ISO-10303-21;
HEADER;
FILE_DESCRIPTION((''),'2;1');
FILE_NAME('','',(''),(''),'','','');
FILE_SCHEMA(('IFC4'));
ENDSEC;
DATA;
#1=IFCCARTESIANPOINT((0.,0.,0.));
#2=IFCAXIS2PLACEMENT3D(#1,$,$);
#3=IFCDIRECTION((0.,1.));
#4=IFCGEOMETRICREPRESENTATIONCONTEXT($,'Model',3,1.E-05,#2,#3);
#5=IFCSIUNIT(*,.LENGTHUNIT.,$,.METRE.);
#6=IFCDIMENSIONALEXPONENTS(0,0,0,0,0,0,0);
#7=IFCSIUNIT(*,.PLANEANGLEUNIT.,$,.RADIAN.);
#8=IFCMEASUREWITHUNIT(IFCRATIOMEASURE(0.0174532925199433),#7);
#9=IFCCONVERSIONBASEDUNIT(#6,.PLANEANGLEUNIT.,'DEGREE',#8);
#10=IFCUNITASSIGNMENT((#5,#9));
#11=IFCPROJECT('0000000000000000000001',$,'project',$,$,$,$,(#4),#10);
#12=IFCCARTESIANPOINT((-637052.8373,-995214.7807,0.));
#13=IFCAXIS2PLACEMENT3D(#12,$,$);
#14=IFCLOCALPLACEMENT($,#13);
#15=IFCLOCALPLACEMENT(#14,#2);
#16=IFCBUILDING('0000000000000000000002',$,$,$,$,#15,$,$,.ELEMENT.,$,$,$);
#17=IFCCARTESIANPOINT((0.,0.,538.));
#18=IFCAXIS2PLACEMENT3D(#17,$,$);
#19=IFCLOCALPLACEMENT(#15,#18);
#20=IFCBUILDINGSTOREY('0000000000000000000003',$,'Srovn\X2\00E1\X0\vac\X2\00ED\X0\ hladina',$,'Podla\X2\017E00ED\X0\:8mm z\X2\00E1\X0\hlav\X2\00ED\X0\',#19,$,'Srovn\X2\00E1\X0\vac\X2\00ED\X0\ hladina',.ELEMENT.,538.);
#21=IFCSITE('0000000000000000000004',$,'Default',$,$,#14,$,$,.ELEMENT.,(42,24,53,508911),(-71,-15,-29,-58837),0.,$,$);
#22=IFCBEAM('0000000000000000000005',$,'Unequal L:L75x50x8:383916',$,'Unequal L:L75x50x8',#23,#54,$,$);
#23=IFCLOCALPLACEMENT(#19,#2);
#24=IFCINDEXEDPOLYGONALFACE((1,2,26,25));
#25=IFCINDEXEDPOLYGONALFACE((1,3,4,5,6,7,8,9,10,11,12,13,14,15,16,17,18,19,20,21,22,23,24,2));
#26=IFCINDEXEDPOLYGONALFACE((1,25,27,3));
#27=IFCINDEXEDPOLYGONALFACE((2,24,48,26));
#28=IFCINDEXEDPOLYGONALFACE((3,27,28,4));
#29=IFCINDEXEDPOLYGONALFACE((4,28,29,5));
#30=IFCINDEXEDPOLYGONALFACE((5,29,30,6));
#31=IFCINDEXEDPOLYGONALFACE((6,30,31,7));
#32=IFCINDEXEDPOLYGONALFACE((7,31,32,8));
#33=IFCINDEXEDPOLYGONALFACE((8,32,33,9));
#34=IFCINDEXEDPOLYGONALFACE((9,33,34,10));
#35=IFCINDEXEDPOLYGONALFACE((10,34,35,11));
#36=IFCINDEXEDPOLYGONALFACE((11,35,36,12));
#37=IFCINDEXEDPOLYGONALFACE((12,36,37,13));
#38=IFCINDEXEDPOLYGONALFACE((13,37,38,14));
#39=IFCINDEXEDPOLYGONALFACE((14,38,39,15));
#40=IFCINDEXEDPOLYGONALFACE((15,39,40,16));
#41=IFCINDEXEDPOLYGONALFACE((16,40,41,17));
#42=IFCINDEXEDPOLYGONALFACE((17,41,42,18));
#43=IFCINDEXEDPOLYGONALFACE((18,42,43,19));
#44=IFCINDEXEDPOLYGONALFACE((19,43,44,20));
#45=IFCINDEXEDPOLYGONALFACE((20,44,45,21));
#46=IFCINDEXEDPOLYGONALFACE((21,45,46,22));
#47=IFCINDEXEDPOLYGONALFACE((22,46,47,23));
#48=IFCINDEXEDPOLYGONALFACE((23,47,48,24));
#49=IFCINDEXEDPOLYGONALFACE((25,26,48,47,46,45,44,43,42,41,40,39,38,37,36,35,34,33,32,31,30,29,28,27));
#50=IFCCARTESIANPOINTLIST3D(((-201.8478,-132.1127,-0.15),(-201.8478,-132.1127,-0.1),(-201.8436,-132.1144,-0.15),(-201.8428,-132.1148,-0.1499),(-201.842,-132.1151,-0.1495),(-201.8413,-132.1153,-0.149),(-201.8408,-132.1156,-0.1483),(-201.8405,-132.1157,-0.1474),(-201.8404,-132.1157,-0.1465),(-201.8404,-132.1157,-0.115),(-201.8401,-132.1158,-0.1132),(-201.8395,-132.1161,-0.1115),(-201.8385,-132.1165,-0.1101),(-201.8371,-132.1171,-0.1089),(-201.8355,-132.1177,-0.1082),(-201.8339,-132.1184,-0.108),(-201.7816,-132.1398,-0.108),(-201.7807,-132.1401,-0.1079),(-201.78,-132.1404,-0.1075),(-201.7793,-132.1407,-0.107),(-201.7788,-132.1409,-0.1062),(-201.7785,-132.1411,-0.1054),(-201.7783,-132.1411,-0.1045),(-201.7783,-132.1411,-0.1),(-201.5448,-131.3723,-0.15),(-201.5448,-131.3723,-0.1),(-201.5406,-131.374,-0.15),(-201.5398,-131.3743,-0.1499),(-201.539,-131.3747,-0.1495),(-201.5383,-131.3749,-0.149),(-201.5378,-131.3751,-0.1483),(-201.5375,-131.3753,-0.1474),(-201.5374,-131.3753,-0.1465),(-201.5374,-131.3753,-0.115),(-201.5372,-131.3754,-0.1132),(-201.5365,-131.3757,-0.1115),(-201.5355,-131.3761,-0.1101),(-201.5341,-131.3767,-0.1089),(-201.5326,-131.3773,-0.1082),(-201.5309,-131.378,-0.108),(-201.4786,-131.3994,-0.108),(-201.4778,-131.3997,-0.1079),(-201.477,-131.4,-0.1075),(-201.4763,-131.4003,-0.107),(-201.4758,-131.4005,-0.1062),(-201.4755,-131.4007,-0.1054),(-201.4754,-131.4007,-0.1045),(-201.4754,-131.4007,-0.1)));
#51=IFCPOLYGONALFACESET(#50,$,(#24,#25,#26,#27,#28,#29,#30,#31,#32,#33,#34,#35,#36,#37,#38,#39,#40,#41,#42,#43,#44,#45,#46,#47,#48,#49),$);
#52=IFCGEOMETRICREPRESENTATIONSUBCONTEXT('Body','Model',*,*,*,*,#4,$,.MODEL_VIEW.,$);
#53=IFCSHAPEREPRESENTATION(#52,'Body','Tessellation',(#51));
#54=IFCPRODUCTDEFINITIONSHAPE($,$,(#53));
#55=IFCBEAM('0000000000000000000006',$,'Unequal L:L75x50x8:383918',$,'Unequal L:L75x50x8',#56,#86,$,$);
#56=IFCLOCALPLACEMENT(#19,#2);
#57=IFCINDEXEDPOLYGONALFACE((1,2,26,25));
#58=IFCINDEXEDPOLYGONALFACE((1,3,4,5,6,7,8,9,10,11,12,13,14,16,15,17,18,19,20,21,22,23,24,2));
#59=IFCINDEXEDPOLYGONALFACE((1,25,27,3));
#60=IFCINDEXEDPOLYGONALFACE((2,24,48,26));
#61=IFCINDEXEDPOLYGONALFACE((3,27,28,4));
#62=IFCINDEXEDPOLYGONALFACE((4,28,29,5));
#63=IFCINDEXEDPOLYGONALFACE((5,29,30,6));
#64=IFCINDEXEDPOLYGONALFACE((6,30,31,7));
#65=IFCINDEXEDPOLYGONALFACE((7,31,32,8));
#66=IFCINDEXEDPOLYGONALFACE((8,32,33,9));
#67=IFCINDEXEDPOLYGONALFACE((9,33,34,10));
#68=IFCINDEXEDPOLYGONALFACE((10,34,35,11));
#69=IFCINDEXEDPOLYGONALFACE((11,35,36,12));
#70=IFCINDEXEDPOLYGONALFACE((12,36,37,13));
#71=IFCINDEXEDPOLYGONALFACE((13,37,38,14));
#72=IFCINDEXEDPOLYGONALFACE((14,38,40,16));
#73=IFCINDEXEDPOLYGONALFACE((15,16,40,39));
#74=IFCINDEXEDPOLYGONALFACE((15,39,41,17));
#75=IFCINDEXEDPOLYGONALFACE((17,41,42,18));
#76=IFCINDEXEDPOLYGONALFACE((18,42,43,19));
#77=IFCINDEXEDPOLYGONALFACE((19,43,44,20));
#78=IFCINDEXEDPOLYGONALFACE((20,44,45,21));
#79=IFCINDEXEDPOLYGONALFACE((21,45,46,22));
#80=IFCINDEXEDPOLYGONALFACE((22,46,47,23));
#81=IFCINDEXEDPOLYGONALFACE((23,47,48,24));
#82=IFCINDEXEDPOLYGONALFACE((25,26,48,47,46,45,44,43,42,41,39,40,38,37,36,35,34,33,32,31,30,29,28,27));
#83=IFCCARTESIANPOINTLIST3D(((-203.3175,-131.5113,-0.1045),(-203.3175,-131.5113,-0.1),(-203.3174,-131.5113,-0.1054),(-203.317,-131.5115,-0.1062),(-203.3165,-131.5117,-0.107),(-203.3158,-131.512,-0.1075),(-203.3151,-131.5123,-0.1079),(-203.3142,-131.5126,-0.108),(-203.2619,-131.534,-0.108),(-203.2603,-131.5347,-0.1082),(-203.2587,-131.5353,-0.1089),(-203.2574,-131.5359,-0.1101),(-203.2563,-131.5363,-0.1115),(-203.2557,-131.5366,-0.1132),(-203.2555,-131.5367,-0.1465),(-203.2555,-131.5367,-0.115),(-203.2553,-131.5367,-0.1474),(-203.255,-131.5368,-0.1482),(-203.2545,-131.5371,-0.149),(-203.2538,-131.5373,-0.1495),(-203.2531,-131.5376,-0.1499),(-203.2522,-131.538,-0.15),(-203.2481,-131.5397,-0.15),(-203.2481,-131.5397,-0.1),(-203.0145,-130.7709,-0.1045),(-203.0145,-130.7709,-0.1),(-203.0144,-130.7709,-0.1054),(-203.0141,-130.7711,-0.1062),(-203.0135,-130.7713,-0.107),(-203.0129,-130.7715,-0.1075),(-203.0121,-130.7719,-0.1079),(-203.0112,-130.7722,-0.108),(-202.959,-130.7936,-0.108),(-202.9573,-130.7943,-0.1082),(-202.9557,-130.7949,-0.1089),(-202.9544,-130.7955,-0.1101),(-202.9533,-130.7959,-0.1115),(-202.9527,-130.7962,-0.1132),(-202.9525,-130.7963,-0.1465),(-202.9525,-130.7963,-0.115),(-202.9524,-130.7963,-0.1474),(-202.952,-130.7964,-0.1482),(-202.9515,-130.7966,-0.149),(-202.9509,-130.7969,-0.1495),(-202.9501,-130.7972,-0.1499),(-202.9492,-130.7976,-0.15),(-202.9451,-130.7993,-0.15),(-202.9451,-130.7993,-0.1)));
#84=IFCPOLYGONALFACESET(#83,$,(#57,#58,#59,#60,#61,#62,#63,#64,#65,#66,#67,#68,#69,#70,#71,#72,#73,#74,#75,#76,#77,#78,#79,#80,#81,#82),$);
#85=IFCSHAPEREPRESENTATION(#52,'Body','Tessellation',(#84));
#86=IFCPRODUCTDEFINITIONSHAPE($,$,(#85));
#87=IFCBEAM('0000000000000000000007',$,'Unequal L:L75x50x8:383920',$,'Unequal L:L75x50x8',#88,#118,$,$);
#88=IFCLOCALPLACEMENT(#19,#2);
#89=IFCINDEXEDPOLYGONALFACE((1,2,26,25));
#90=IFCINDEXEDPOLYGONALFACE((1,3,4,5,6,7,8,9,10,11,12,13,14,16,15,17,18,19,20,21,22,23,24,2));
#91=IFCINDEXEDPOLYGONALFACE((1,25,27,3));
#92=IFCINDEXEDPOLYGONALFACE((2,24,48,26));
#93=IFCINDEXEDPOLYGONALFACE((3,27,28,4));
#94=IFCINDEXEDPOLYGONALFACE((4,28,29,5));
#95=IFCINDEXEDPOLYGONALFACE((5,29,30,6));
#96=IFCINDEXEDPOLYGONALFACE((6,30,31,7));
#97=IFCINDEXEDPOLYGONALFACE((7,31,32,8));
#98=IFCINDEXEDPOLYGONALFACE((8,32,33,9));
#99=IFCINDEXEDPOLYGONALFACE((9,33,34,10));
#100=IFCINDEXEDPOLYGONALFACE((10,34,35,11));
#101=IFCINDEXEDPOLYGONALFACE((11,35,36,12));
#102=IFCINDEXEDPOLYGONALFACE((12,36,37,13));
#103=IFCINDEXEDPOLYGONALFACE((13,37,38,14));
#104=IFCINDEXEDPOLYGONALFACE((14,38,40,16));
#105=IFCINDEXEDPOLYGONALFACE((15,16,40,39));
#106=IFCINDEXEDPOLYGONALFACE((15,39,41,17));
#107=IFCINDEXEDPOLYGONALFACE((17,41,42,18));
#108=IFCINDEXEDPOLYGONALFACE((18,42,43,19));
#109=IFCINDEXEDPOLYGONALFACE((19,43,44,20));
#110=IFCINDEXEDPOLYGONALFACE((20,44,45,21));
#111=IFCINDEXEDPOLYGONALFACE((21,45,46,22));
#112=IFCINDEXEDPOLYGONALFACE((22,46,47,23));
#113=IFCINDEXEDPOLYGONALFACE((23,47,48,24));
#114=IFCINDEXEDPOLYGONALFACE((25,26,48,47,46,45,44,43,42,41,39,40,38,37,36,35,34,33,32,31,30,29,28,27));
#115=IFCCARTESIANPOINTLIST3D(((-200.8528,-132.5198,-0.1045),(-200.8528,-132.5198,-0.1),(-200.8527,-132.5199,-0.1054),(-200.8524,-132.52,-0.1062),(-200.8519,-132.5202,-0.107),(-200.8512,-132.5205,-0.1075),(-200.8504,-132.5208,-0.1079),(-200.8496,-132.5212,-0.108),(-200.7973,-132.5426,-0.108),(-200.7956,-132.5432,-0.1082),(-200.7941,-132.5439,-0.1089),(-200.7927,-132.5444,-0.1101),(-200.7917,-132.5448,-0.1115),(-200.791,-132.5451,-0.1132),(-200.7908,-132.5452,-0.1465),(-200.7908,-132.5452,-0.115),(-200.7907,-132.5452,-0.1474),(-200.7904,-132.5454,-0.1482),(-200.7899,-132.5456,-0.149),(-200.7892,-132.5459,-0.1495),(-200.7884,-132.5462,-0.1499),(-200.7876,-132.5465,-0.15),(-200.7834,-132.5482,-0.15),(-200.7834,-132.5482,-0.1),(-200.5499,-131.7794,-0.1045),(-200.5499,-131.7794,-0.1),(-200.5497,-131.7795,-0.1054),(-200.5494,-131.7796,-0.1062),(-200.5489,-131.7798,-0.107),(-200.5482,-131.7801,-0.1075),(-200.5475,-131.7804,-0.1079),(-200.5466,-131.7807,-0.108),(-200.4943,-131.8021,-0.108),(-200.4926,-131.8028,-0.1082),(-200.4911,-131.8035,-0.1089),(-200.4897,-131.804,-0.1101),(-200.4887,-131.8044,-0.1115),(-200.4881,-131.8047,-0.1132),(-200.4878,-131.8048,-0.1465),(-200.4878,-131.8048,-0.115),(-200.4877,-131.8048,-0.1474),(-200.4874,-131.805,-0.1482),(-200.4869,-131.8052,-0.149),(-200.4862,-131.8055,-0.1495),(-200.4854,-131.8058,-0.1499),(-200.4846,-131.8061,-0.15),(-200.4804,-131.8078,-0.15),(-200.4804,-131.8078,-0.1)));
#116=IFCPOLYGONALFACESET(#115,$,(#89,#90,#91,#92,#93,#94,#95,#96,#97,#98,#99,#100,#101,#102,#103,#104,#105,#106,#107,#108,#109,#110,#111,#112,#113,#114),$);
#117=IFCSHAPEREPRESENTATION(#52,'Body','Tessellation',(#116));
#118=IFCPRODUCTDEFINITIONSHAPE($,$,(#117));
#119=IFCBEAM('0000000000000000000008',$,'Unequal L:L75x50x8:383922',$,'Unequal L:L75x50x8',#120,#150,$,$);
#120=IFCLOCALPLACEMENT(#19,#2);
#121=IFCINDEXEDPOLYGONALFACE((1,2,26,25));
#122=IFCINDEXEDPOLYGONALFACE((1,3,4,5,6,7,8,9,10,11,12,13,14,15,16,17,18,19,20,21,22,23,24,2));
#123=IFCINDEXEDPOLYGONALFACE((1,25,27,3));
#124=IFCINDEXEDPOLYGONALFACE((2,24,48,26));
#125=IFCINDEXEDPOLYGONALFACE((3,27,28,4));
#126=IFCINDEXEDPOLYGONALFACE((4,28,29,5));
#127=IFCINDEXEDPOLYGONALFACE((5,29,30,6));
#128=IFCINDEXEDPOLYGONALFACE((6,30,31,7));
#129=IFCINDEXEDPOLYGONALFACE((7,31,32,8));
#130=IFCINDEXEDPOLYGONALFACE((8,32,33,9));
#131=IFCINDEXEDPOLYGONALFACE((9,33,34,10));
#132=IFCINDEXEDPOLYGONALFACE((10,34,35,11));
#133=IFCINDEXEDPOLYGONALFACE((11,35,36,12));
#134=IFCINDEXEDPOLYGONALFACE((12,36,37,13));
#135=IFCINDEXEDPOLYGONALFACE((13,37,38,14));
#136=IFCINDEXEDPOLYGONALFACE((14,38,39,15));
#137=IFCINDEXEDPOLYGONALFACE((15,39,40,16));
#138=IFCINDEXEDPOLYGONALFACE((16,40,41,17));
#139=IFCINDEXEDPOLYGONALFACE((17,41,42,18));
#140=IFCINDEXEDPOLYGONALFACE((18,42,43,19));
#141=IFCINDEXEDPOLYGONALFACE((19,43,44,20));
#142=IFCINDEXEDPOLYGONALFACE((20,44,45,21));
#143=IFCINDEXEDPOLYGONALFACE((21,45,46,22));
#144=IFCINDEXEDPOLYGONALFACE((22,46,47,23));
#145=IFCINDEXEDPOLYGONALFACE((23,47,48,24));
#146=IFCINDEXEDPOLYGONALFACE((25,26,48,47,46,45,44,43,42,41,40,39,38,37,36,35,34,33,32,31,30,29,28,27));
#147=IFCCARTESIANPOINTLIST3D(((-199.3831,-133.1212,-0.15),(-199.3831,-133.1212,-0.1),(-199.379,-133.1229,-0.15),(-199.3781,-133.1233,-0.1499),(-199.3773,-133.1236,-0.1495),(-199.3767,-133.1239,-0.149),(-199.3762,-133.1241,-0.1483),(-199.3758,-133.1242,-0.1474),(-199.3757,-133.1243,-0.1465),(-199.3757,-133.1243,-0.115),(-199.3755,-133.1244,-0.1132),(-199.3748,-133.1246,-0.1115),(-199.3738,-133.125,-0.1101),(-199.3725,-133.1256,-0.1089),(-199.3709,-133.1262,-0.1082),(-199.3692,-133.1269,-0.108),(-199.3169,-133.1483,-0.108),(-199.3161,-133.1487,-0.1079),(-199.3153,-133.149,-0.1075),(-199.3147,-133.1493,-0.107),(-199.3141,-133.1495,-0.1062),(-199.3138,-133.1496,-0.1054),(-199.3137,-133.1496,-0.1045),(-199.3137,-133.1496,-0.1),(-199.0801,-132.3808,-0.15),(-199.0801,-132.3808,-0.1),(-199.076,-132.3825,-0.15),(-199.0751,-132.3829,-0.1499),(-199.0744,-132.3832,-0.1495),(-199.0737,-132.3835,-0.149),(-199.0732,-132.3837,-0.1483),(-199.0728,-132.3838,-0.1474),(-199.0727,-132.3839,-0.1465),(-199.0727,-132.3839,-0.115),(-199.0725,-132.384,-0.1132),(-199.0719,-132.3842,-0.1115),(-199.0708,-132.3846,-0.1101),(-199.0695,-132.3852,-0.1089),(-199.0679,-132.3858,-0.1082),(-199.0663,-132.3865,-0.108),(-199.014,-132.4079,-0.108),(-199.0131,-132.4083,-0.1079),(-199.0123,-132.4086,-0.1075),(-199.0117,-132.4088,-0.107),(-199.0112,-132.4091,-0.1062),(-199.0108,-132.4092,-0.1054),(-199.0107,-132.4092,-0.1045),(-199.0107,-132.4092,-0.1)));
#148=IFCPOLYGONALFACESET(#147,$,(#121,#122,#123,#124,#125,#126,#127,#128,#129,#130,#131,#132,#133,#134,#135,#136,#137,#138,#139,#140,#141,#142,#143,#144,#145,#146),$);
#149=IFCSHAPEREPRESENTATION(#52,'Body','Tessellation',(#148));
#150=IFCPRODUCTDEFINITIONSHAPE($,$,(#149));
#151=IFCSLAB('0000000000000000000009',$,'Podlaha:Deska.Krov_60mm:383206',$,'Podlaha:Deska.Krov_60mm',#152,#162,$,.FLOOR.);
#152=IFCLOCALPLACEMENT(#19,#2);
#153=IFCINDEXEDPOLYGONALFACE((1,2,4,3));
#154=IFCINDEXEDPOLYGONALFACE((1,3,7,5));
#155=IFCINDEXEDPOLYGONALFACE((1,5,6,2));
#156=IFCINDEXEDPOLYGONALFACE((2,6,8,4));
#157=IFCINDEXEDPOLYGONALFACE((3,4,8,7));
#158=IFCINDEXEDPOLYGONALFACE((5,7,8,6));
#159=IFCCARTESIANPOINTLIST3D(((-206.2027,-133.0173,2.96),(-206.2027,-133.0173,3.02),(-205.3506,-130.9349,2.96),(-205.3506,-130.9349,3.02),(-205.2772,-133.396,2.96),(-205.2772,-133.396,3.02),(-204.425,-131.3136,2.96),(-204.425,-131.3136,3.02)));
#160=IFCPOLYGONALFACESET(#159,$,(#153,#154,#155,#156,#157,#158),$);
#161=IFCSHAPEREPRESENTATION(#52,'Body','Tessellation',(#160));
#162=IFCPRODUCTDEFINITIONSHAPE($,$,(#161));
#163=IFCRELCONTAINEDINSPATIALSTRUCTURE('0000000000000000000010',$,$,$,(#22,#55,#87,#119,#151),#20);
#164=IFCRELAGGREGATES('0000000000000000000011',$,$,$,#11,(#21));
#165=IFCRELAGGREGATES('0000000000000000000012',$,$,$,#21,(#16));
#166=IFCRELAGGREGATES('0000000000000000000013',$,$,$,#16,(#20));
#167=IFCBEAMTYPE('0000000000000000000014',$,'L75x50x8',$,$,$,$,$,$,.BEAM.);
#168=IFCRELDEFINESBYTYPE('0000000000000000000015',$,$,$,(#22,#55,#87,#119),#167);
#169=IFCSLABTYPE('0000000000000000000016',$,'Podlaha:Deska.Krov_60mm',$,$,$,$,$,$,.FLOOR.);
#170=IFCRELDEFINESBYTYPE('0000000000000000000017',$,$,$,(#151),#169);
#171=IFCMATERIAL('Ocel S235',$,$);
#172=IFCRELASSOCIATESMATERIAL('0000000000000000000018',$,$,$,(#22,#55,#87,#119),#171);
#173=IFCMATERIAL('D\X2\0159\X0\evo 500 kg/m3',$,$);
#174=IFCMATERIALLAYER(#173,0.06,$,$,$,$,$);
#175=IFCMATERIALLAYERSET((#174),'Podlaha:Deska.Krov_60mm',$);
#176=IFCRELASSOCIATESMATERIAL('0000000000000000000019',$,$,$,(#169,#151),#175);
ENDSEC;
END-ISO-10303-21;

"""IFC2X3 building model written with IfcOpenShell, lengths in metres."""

from ifc_helpers import new_model, entity, si_unit, converted_unit, direction, frame, frame_2d, origin, origin_2d_with_axis, place, context, subcontext, project, spatial, polyline, circle_curve, parameter, trimmed, segment, composite_curve, rectangle, outline, extrude, material, layer, layer_set, layer_usage, type_object, element, save


model = new_model("IFC2X3")

# Units and contexts
model_context = context("Model", 3, precision=1e-05, world=origin(), true_north=direction((0.0, 1.0)))
body_context = subcontext(model_context, "Body", "Model", "MODEL_VIEW")
ifc_project = project(units=[si_unit("LENGTHUNIT", "METRE"), converted_unit("PLANEANGLEUNIT", "DEGREE", entity("IfcRatioMeasure", 0.0174532925199433), si_unit("PLANEANGLEUNIT", "RADIAN"), dimensions=[0, 0, 0, 0, 0, 0, 0])], contexts=[model_context])

# Site, building, storey
site_placement = place(None, frame((-637052.8373, -995214.7807, 0.0)))
site = spatial("IfcSite", under=ifc_project, at=site_placement, Name="Default", CompositionType="ELEMENT", RefLatitude=(42, 24, 53, 508911), RefLongitude=(-71, -15, -29, -58837), RefElevation=0.0)
building_placement = place(site_placement, origin())
building = spatial("IfcBuilding", under=site, at=building_placement, CompositionType="ELEMENT")
storey_placement = place(building_placement, frame((0.0, 0.0, 538.0)))
storey = spatial("IfcBuildingStorey", under=building, at=storey_placement, Name="Srovnávací hladina", ObjectType="Podlaží:8mm záhlaví", LongName="Srovnávací hladina", CompositionType="ELEMENT", Elevation=538.0)

# Beams
ifc_material_1 = material(Name="Ocel S235")
beam_type = type_object("IfcBeamType", Name="L75x50x8", PredefinedType="BEAM")
beam_1_placement = place(storey_placement, frame((-201.7693, -132.1189, 0.0), z_axis=(0.0, 0.0, 1.0), x_axis=(0.378722, 0.92551, 0.0)))
element("IfcBeam", 1, at=beam_1_placement, inside=storey, type_object=beam_type, material=ifc_material_1, Name="Unequal L:L75x50x8:383916", ObjectType="Unequal L:L75x50x8", context=body_context, shape_type="SweptSolid", body=[
    extrude(outline(composite_curve([segment(polyline([(-0.0202, -0.0464), (-0.0157, -0.0464)]), True, "CONTINUOUS"), segment(trimmed(circle_curve(frame_2d((-0.0157, -0.0429), x_axis=(0.0, -1.0)), 0.0035), [parameter(0.0)], [parameter(90.0)], True, "PARAMETER"), True, "CONTINUOUS"), segment(polyline([(-0.0122, -0.0429), (-0.0122, 0.0136)]), True, "CONTINUOUS"), segment(trimmed(circle_curve(frame_2d((-0.0052, 0.0136), x_axis=(-1.0, 0.0)), 0.007), [parameter(270.0)], [parameter(0.0)], True, "PARAMETER"), False, "CONTINUOUS"), segment(polyline([(-0.0052, 0.0206), (0.0263, 0.0206)]), True, "CONTINUOUS"), segment(trimmed(circle_curve(frame_2d((0.0263, 0.0241), x_axis=(0.0, -1.0)), 0.0035), [parameter(0.0)], [parameter(90.0)], True, "PARAMETER"), True, "CONTINUOUS"), segment(polyline([(0.0298, 0.0241), (0.0298, 0.0286)]), True, "CONTINUOUS"), segment(polyline([(0.0298, 0.0286), (-0.0202, 0.0286)]), True, "CONTINUOUS"), segment(polyline([(-0.0202, 0.0286), (-0.0202, -0.0464)]), True, "CONTINUOUS")], self_intersect=False)), frame((-0.024, 0.0464, -0.1202), z_axis=(1.0, 0.0, 0.0), x_axis=(0.0, 0.0, -1.0)), (0.0, 0.0, 1.0), 0.8),
])
beam_2_placement = place(storey_placement, frame((-203.3084, -131.4891, 0.0), z_axis=(0.0, 0.0, 1.0), x_axis=(0.378722, 0.92551, 0.0)))
element("IfcBeam", 2, at=beam_2_placement, inside=storey, type_object=beam_type, material=ifc_material_1, Name="Unequal L:L75x50x8:383918", ObjectType="Unequal L:L75x50x8", context=body_context, shape_type="SweptSolid", body=[
    extrude(outline(composite_curve([segment(polyline([(-0.0202, -0.0286), (0.0298, -0.0286)]), True, "CONTINUOUS"), segment(polyline([(0.0298, -0.0286), (0.0298, -0.0241)]), True, "CONTINUOUS"), segment(trimmed(circle_curve(frame_2d((0.0263, -0.0241), x_axis=(1.0, 0.0)), 0.0035), [parameter(0.0)], [parameter(90.0)], True, "PARAMETER"), True, "CONTINUOUS"), segment(polyline([(0.0263, -0.0206), (-0.0052, -0.0206)]), True, "CONTINUOUS"), segment(trimmed(circle_curve(frame_2d((-0.0052, -0.0136), x_axis=(0.0, -1.0)), 0.007), [parameter(270.0)], [parameter(0.0)], True, "PARAMETER"), False, "CONTINUOUS"), segment(polyline([(-0.0122, -0.0136), (-0.0122, 0.0429)]), True, "CONTINUOUS"), segment(trimmed(circle_curve(frame_2d((-0.0157, 0.0429), x_axis=(1.0, 0.0)), 0.0035), [parameter(0.0)], [parameter(90.0)], True, "PARAMETER"), True, "CONTINUOUS"), segment(polyline([(-0.0157, 0.0464), (-0.0202, 0.0464)]), True, "CONTINUOUS"), segment(polyline([(-0.0202, 0.0464), (-0.0202, -0.0286)]), True, "CONTINUOUS")], self_intersect=False)), frame((-0.024, -0.0464, -0.1202), z_axis=(1.0, 0.0, 0.0), x_axis=(0.0, 0.0, -1.0)), (0.0, 0.0, 1.0), 0.8),
])
beam_3_placement = place(storey_placement, frame((-200.8437, -132.4976, 0.0), z_axis=(0.0, 0.0, 1.0), x_axis=(0.378722, 0.92551, 0.0)))
element("IfcBeam", 3, at=beam_3_placement, inside=storey, type_object=beam_type, material=ifc_material_1, Name="Unequal L:L75x50x8:383920", ObjectType="Unequal L:L75x50x8", context=body_context, shape_type="SweptSolid", body=[
    extrude(outline(composite_curve([segment(polyline([(-0.0202, -0.0286), (0.0298, -0.0286)]), True, "CONTINUOUS"), segment(polyline([(0.0298, -0.0286), (0.0298, -0.0241)]), True, "CONTINUOUS"), segment(trimmed(circle_curve(frame_2d((0.0263, -0.0241), x_axis=(1.0, 0.0)), 0.0035), [parameter(0.0)], [parameter(90.0)], True, "PARAMETER"), True, "CONTINUOUS"), segment(polyline([(0.0263, -0.0206), (-0.0052, -0.0206)]), True, "CONTINUOUS"), segment(trimmed(circle_curve(frame_2d((-0.0052, -0.0136), x_axis=(0.0, -1.0)), 0.007), [parameter(270.0)], [parameter(0.0)], True, "PARAMETER"), False, "CONTINUOUS"), segment(polyline([(-0.0122, -0.0136), (-0.0122, 0.0429)]), True, "CONTINUOUS"), segment(trimmed(circle_curve(frame_2d((-0.0157, 0.0429), x_axis=(1.0, 0.0)), 0.0035), [parameter(0.0)], [parameter(90.0)], True, "PARAMETER"), True, "CONTINUOUS"), segment(polyline([(-0.0157, 0.0464), (-0.0202, 0.0464)]), True, "CONTINUOUS"), segment(polyline([(-0.0202, 0.0464), (-0.0202, -0.0286)]), True, "CONTINUOUS")], self_intersect=False)), frame((-0.024, -0.0464, -0.1202), z_axis=(1.0, 0.0, 0.0), x_axis=(0.0, 0.0, -1.0)), (0.0, 0.0, 1.0), 0.8),
])
beam_4_placement = place(storey_placement, frame((-199.3046, -133.1274, 0.0), z_axis=(0.0, 0.0, 1.0), x_axis=(0.378722, 0.92551, 0.0)))
element("IfcBeam", 4, at=beam_4_placement, inside=storey, type_object=beam_type, material=ifc_material_1, Name="Unequal L:L75x50x8:383922", ObjectType="Unequal L:L75x50x8", context=body_context, shape_type="SweptSolid", body=[
    extrude(outline(composite_curve([segment(polyline([(-0.0202, -0.0464), (-0.0157, -0.0464)]), True, "CONTINUOUS"), segment(trimmed(circle_curve(frame_2d((-0.0157, -0.0429), x_axis=(0.0, -1.0)), 0.0035), [parameter(0.0)], [parameter(90.0)], True, "PARAMETER"), True, "CONTINUOUS"), segment(polyline([(-0.0122, -0.0429), (-0.0122, 0.0136)]), True, "CONTINUOUS"), segment(trimmed(circle_curve(frame_2d((-0.0052, 0.0136), x_axis=(-1.0, 0.0)), 0.007), [parameter(270.0)], [parameter(0.0)], True, "PARAMETER"), False, "CONTINUOUS"), segment(polyline([(-0.0052, 0.0206), (0.0263, 0.0206)]), True, "CONTINUOUS"), segment(trimmed(circle_curve(frame_2d((0.0263, 0.0241), x_axis=(0.0, -1.0)), 0.0035), [parameter(0.0)], [parameter(90.0)], True, "PARAMETER"), True, "CONTINUOUS"), segment(polyline([(0.0298, 0.0241), (0.0298, 0.0286)]), True, "CONTINUOUS"), segment(polyline([(0.0298, 0.0286), (-0.0202, 0.0286)]), True, "CONTINUOUS"), segment(polyline([(-0.0202, 0.0286), (-0.0202, -0.0464)]), True, "CONTINUOUS")], self_intersect=False)), frame((-0.024, 0.0464, -0.1202), z_axis=(1.0, 0.0, 0.0), x_axis=(0.0, 0.0, -1.0)), (0.0, 0.0, 1.0), 0.8),
])

# Slab
ifc_material_2 = material(Name="Dřevo 500 kg/m3")
ifc_layer_1 = layer(ifc_material_2, 0.06)
ifc_layer_set_1 = layer_set([ifc_layer_1], Name="Podlaha:Deska.Krov_60mm")
ifc_layer_usage_1 = layer_usage(ifc_layer_set_1, "AXIS3", "POSITIVE", 0.0)
slab_type_1 = type_object("IfcSlabType", Name="Podlaha:Deska.Krov_60mm", PredefinedType="FLOOR", material=ifc_layer_set_1)
slab_1_placement = place(storey_placement, origin())
element("IfcSlab", 5, at=slab_1_placement, inside=storey, type_object=slab_type_1, material=ifc_layer_usage_1, Name="Podlaha:Deska.Krov_60mm:383206", ObjectType="Podlaha:Deska.Krov_60mm", PredefinedType="FLOOR", context=body_context, shape_type="SweptSolid", body=[
    extrude(rectangle(XDim=2.25, YDim=1.0, at=origin_2d_with_axis()), frame((-205.3139, -132.1654, 3.02), z_axis=(0.0, 0.0, -1.0), x_axis=(-0.378722, -0.92551, 0.0)), (0.0, 0.0, 1.0), 0.06),
])

save(model, "model.ifc")
